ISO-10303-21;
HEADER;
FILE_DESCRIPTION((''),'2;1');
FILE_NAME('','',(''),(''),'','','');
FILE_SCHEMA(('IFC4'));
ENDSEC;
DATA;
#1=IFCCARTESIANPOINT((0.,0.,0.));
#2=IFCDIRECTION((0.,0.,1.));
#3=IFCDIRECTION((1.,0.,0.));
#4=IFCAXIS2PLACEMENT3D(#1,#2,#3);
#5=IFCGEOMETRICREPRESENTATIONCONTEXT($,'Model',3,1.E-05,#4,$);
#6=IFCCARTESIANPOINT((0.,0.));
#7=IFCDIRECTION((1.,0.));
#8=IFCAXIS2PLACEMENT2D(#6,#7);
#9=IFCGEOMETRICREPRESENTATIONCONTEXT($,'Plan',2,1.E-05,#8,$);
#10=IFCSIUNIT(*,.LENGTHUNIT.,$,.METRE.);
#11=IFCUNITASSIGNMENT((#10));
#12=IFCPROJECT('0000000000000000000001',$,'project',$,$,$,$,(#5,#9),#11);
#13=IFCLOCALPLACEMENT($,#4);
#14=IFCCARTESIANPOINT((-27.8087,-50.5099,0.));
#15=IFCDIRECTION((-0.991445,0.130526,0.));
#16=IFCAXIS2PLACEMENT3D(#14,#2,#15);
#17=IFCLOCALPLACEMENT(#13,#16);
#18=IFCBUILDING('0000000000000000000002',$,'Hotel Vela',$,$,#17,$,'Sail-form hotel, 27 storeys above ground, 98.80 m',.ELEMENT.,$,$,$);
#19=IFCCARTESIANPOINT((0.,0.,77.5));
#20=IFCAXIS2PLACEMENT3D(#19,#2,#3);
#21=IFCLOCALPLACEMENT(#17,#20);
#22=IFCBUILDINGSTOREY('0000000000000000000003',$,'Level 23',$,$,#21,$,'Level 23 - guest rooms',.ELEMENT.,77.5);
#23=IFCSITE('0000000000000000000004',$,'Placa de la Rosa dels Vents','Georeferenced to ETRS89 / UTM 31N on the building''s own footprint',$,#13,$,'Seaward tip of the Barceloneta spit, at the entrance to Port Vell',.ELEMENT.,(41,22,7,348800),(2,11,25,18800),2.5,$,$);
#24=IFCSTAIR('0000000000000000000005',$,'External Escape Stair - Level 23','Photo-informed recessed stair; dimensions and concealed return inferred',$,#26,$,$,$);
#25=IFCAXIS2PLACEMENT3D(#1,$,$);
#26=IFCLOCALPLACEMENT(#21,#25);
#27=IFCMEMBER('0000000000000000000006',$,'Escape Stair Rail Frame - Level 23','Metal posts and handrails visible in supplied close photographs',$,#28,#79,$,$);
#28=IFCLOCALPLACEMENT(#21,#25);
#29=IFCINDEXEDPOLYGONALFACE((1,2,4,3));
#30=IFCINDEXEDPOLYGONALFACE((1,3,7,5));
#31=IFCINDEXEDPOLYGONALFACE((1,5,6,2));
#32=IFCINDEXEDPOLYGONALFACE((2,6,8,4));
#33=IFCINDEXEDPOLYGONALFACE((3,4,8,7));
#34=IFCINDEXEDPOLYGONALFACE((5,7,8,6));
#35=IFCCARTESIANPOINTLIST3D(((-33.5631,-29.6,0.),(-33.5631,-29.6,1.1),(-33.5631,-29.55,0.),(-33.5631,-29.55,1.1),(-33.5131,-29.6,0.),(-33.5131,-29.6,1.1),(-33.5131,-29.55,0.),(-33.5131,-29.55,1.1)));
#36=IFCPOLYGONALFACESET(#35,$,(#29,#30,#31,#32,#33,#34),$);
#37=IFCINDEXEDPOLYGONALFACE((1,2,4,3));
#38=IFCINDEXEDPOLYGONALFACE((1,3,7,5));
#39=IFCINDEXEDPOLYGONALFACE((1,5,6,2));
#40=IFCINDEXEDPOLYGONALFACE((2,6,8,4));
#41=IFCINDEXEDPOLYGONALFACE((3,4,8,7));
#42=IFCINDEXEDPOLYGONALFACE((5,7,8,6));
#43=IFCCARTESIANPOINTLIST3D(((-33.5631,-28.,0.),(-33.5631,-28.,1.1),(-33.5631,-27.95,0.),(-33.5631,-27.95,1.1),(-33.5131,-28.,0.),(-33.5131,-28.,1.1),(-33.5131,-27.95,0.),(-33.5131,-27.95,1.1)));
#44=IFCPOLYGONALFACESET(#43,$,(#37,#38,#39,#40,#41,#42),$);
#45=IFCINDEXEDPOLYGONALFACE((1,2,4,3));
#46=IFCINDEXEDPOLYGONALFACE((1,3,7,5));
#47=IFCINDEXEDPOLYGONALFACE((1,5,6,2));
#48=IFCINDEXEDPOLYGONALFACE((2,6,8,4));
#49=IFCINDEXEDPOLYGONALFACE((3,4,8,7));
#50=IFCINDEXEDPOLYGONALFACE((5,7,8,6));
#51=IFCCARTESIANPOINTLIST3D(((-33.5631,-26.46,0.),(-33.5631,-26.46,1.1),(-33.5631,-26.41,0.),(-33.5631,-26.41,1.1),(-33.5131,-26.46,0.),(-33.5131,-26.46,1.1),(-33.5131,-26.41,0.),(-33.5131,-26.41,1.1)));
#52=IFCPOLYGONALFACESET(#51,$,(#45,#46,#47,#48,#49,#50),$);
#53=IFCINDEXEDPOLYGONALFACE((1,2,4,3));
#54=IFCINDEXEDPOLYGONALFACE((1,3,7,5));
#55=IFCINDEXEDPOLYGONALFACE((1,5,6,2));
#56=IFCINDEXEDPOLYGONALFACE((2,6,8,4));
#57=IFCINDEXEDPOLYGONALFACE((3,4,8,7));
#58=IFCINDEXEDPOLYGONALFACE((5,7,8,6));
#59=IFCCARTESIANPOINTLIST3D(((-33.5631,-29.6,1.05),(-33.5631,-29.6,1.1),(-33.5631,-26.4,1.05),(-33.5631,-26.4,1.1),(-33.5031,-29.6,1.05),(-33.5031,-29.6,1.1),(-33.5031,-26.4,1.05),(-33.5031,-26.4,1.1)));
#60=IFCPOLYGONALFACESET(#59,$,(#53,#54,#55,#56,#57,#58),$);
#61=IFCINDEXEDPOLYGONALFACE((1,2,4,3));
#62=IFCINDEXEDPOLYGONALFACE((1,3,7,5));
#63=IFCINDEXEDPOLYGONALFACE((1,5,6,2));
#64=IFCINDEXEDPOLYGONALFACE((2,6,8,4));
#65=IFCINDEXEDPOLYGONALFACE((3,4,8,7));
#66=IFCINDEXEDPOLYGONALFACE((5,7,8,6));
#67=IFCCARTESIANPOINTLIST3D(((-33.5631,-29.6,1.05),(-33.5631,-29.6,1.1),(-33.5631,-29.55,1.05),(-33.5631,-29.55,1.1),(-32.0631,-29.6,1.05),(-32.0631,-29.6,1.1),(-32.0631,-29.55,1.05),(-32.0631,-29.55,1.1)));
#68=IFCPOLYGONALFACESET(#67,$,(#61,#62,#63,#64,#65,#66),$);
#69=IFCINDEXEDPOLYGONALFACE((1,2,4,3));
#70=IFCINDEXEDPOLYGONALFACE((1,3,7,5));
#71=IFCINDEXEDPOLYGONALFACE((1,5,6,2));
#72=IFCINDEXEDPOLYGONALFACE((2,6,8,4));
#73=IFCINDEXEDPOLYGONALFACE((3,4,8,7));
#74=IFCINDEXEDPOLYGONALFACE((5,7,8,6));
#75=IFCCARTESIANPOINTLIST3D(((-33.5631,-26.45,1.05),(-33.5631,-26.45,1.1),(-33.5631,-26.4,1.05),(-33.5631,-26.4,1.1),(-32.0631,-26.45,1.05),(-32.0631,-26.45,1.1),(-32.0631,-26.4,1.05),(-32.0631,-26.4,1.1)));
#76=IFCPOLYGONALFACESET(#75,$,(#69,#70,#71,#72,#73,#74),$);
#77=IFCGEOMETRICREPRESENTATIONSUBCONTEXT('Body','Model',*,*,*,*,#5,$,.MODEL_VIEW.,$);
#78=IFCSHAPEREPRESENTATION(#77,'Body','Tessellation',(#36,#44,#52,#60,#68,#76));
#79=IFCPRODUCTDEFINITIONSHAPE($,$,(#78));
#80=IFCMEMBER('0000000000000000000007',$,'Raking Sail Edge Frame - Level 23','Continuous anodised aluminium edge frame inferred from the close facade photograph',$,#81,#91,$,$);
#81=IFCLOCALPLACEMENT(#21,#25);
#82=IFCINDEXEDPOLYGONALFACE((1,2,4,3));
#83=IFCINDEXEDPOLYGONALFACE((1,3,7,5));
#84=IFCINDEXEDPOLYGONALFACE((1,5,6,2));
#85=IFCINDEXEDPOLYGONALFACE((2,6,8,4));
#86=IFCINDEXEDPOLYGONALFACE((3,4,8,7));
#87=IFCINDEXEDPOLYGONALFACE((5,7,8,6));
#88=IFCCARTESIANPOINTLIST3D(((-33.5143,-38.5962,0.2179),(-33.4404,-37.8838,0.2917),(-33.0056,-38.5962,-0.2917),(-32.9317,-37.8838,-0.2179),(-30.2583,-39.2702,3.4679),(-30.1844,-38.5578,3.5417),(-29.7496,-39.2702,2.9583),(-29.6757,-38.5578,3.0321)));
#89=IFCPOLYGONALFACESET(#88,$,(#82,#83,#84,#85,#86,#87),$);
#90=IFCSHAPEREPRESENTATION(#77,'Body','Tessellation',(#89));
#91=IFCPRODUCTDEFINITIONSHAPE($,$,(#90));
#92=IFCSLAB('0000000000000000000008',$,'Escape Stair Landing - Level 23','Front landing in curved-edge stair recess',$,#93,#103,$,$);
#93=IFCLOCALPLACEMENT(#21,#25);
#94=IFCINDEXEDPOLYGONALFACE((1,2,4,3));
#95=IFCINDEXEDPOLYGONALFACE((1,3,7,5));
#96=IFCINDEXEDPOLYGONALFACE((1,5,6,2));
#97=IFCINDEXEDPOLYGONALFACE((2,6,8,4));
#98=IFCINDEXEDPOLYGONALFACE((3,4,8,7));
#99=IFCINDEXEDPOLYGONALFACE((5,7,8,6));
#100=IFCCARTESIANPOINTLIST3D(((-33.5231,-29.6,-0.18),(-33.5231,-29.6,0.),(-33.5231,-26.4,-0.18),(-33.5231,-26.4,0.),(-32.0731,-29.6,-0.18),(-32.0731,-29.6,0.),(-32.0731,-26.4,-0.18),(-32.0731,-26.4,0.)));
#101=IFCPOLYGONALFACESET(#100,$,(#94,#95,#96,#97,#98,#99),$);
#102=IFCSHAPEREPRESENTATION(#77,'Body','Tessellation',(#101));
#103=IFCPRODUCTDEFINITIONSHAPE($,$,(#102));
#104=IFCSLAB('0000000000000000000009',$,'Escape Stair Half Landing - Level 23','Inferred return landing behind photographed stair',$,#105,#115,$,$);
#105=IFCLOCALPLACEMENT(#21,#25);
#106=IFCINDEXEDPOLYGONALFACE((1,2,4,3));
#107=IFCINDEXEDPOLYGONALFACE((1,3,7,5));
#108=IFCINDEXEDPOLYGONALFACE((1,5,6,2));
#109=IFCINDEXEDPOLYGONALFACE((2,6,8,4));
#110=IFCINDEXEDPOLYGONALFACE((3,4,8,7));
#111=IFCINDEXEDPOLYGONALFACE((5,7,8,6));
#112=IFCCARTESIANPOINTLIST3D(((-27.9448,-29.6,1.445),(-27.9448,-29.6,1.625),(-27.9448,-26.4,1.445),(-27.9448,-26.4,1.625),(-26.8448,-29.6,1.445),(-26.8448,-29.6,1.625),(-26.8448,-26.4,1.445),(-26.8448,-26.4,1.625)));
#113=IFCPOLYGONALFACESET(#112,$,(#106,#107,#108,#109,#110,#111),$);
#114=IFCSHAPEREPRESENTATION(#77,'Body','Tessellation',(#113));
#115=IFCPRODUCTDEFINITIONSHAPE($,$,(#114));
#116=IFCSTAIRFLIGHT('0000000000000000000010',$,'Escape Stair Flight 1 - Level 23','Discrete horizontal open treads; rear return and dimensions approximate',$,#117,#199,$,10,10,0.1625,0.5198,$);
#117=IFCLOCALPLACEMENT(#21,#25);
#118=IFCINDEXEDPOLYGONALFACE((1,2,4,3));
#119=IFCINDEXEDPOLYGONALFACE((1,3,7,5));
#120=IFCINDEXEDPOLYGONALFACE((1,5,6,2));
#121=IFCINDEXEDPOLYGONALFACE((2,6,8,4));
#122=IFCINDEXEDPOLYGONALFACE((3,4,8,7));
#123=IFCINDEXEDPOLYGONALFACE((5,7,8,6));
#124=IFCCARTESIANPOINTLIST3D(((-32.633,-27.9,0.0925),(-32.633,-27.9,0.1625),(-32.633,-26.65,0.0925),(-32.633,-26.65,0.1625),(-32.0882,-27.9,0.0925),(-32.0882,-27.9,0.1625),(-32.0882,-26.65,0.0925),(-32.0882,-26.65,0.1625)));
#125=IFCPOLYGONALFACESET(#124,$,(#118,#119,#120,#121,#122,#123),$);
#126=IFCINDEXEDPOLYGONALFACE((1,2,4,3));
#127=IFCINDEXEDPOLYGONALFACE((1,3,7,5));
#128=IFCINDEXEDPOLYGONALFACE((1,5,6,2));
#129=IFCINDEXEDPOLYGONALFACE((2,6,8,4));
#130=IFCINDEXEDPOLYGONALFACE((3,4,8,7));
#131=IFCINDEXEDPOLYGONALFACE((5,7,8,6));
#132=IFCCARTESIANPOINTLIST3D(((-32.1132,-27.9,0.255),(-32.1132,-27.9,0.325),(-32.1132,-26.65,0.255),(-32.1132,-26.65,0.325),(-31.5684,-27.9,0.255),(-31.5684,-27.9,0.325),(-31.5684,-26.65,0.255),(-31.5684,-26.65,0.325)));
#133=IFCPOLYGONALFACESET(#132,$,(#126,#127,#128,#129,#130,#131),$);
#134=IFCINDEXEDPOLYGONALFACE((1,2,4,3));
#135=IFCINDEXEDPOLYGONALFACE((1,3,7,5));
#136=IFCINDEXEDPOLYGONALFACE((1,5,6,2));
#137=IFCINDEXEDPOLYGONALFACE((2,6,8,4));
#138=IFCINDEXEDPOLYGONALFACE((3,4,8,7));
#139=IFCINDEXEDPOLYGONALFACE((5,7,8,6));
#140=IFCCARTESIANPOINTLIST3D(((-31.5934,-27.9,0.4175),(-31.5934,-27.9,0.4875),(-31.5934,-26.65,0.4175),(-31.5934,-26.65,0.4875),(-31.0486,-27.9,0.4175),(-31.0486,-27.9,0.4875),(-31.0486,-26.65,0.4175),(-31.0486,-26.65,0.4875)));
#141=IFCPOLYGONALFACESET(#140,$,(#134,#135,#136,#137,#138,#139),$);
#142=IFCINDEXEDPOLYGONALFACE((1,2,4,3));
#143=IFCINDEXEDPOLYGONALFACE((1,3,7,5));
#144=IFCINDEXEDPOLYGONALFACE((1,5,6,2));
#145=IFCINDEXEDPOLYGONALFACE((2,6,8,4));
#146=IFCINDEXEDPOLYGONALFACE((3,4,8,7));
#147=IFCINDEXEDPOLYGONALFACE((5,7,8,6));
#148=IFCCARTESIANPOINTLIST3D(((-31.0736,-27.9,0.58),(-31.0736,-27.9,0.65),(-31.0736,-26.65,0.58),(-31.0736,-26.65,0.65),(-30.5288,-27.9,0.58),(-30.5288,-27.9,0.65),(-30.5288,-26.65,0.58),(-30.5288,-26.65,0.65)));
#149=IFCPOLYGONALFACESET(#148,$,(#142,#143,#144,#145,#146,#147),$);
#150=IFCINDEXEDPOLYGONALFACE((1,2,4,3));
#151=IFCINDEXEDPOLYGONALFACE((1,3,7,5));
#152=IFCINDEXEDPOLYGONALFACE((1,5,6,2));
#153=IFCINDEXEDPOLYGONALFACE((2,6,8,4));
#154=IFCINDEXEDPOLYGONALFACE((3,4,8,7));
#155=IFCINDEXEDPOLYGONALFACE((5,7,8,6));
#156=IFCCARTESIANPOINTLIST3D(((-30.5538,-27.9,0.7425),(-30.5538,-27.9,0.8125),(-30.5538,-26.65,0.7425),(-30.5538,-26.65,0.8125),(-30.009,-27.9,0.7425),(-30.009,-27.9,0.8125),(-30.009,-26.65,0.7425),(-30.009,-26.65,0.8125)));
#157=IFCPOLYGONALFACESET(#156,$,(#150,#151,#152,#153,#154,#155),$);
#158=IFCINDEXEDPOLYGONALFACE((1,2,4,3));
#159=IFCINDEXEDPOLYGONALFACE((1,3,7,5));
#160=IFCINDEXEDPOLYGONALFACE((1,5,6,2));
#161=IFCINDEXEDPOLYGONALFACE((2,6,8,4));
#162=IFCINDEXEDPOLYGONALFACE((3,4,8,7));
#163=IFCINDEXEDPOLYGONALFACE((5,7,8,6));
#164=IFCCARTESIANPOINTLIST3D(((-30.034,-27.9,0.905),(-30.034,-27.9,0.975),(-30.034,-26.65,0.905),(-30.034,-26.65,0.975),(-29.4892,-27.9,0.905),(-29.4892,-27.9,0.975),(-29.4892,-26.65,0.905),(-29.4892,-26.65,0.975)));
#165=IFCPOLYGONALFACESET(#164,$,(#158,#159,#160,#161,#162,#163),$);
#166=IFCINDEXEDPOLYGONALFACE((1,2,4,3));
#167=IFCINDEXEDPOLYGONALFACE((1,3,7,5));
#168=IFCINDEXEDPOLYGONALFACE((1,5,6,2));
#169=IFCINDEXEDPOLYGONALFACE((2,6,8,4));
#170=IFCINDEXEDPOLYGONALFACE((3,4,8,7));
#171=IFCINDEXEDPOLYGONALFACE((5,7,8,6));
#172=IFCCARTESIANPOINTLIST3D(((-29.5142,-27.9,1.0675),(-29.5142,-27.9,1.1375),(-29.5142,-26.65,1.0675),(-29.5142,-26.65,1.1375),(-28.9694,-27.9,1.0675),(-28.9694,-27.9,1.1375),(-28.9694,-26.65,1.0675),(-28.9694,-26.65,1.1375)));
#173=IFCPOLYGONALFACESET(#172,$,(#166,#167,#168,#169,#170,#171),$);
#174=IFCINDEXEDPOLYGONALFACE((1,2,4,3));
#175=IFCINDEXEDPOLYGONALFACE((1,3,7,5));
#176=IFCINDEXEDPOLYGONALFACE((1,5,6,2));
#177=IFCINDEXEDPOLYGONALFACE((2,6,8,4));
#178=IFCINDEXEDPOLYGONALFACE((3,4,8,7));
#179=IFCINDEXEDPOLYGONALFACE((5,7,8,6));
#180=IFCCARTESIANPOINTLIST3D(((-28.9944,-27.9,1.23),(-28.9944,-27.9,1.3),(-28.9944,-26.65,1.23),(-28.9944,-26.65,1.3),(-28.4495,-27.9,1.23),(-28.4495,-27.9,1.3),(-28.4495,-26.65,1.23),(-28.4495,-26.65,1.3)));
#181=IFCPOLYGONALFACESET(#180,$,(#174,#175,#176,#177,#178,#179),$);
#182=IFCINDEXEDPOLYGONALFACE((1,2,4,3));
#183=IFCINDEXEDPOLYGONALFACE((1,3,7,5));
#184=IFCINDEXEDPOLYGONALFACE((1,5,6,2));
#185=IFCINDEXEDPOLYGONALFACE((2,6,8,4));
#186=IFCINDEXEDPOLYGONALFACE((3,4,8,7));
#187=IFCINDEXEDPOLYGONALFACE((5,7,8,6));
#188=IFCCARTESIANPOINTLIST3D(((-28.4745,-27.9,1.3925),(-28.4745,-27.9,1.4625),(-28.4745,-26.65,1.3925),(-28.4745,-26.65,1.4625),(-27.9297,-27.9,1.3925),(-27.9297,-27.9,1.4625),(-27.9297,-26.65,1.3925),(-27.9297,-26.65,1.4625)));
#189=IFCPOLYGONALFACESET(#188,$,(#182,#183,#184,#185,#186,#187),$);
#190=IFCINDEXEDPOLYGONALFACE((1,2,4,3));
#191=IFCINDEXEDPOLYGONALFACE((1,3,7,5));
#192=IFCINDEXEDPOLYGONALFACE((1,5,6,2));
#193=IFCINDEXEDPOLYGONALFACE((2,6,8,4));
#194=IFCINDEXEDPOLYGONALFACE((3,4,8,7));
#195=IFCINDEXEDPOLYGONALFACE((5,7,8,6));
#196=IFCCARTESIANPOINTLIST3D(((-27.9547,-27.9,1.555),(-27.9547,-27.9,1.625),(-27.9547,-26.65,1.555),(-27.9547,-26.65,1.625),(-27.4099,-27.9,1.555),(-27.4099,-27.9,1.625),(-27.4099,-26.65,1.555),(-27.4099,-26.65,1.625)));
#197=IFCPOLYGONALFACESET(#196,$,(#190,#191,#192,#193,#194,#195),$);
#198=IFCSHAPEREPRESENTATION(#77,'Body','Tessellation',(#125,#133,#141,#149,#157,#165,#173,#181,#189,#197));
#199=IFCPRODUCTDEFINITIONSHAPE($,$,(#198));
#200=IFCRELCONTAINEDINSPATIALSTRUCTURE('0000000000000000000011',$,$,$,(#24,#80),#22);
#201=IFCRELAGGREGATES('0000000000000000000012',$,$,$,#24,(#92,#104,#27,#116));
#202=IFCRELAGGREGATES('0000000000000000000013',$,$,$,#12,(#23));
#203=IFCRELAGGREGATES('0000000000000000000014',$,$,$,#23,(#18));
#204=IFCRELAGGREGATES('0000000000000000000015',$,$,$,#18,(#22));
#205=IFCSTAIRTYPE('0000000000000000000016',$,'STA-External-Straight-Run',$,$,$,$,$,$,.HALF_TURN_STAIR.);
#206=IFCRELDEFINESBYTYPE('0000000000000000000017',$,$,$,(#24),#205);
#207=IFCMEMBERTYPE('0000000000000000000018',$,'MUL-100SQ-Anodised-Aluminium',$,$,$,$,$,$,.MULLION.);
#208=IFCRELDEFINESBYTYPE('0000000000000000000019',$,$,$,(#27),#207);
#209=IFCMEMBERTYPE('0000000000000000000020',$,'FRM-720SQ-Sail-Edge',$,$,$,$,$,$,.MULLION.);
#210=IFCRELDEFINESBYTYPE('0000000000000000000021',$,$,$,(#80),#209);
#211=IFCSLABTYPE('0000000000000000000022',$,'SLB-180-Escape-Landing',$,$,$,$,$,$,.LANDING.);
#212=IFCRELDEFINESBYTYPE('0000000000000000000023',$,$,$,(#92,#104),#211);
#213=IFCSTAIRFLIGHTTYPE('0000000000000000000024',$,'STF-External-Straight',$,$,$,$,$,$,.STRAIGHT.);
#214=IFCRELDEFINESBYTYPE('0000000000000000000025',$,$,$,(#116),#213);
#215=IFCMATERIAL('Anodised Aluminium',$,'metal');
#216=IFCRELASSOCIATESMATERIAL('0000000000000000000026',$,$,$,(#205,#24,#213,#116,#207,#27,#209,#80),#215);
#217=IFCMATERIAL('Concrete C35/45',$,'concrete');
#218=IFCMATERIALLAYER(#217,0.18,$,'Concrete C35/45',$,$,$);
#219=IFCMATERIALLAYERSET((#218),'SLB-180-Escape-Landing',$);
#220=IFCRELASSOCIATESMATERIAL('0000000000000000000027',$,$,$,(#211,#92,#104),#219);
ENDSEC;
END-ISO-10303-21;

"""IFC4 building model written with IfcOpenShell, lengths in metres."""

from ifc_helpers import new_model, si_unit, frame, origin_with_axes, origin_2d_with_axis, place, context, subcontext, project, spatial, line, indexed_curve, rectangle, outline, extrude, material, layer, layer_set, layer_usage, material_profile, profile_set, profile_usage, type_object, element, aggregate, save


model = new_model("IFC4")

# Units and contexts
model_context = context("Model", 3, precision=1e-05, world=origin_with_axes())
plan_context = context("Plan", 2, precision=1e-05, world=origin_2d_with_axis())
body_context = subcontext(model_context, "Body", "Model", "MODEL_VIEW")
ifc_project = project(units=[si_unit("LENGTHUNIT", "METRE")], contexts=[model_context, plan_context])

# Site, building, storey
site_placement = place(None, origin_with_axes())
site = spatial("IfcSite", under=ifc_project, at=site_placement, Name="Placa de la Rosa dels Vents", Description="Georeferenced to ETRS89 / UTM 31N on the building's own footprint", LongName="Seaward tip of the Barceloneta spit, at the entrance to Port Vell", CompositionType="ELEMENT", RefLatitude=(41, 22, 7, 348800), RefLongitude=(2, 11, 25, 18800), RefElevation=2.5)
building_placement = place(site_placement, frame((-27.8087, -50.5099, 0.0), z_axis=(0.0, 0.0, 1.0), x_axis=(-0.991445, 0.130526, 0.0)))
building = spatial("IfcBuilding", under=site, at=building_placement, Name="Hotel Vela", LongName="Sail-form hotel, 27 storeys above ground, 98.80 m", CompositionType="ELEMENT")
storey_placement = place(building_placement, frame((0.0, 0.0, 77.5), z_axis=(0.0, 0.0, 1.0), x_axis=(1.0, 0.0, 0.0)))
storey = spatial("IfcBuildingStorey", under=building, at=storey_placement, Name="Level 23", LongName="Level 23 - guest rooms", CompositionType="ELEMENT", Elevation=77.5)

# Stair, member
ifc_material_1 = material(Name="Anodised Aluminium", Category="metal")
stair_type = type_object("IfcStairType", Name="STA-External-Straight-Run", PredefinedType="HALF_TURN_STAIR", material=ifc_material_1)
stair_placement = place(storey_placement, frame((0.0, 0.0, -77.5), z_axis=(0.0, 0.0, 1.0), x_axis=(1.0, 0.0, 0.0)))
stair = element("IfcStair", 1, at=stair_placement, inside=storey, type_object=stair_type, material=ifc_material_1, Name="External Escape Stair - Level 23", Description="Photo-informed recessed stair; dimensions and concealed return inferred")
ifc_material_profile_1 = material_profile(ifc_material_1, rectangle(XDim=0.1, YDim=0.1))
ifc_profile_set_1 = profile_set([ifc_material_profile_1], Name="MUL-100SQ-Anodised-Aluminium")
ifc_profile_usage_1 = profile_usage(ifc_profile_set_1)
member_type_1 = type_object("IfcMemberType", Name="MUL-100SQ-Anodised-Aluminium", PredefinedType="MULLION", material=ifc_profile_set_1)
member_1_placement = place(stair_placement, origin_with_axes())
member_1 = element("IfcMember", 2, at=member_1_placement, type_object=member_type_1, material=ifc_profile_usage_1, Name="Escape Stair Rail Frame - Level 23", Description="Metal posts and handrails visible in supplied close photographs", context=body_context, shape_type="SweptSolid", body=[
    extrude(outline(indexed_curve([(0.0, 0.0), (0.05, 0.0), (0.05, 0.05), (0.0, 0.05)], segments=[line(1, 2, 3, 4, 1)])), frame((-33.5631, -29.6, 77.5), z_axis=(0.0, 0.0, 1.0), x_axis=(1.0, 0.0, 0.0)), (0.0, 0.0, 1.0), 1.1),
    extrude(outline(indexed_curve([(0.0, 0.0), (0.05, 0.0), (0.05, 0.05), (0.0, 0.05)], segments=[line(1, 2, 3, 4, 1)])), frame((-33.5631, -28.0, 77.5), z_axis=(0.0, 0.0, 1.0), x_axis=(1.0, 0.0, 0.0)), (0.0, 0.0, 1.0), 1.1),
    extrude(outline(indexed_curve([(0.0, 0.0), (0.05, 0.0), (0.05, 0.05), (0.0, 0.05)], segments=[line(1, 2, 3, 4, 1)])), frame((-33.5631, -26.46, 77.5), z_axis=(0.0, 0.0, 1.0), x_axis=(1.0, 0.0, 0.0)), (0.0, 0.0, 1.0), 1.1),
    extrude(outline(indexed_curve([(0.0, 0.0), (0.06, 0.0), (0.06, 3.2), (0.0, 3.2)], segments=[line(1, 2, 3, 4, 1)])), frame((-33.5631, -29.6, 78.55), z_axis=(0.0, 0.0, 1.0), x_axis=(1.0, 0.0, 0.0)), (0.0, 0.0, 1.0), 0.05),
    extrude(outline(indexed_curve([(0.0, 0.0), (1.5, 0.0), (1.5, 0.05), (0.0, 0.05)], segments=[line(1, 2, 3, 4, 1)])), frame((-33.5631, -29.6, 78.55), z_axis=(0.0, 0.0, 1.0), x_axis=(1.0, 0.0, 0.0)), (0.0, 0.0, 1.0), 0.05),
    extrude(outline(indexed_curve([(0.0, 0.0), (1.5, 0.0), (1.5, 0.05), (0.0, 0.05)], segments=[line(1, 2, 3, 4, 1)])), frame((-33.5631, -26.45, 78.55), z_axis=(0.0, 0.0, 1.0), x_axis=(1.0, 0.0, 0.0)), (0.0, 0.0, 1.0), 0.05),
])

# Member
ifc_material_profile_2 = material_profile(ifc_material_1, rectangle(XDim=0.72, YDim=0.72))
ifc_profile_set_2 = profile_set([ifc_material_profile_2], Name="FRM-720SQ-Sail-Edge")
ifc_profile_usage_2 = profile_usage(ifc_profile_set_2)
member_type_2 = type_object("IfcMemberType", Name="FRM-720SQ-Sail-Edge", PredefinedType="MULLION", material=ifc_profile_set_2)
member_2_placement = place(storey_placement, frame((-33.223, -38.24, 0.0), z_axis=(0.700283, -0.14496, 0.698992), x_axis=(0.706454, 0.0, -0.707759)))
element("IfcMember", 3, at=member_2_placement, inside=storey, type_object=member_type_2, material=ifc_profile_usage_2, Name="Raking Sail Edge Frame - Level 23", Description="Continuous anodised aluminium edge frame inferred from the close facade photograph", context=body_context, shape_type="SweptSolid", body=[
    extrude(outline(indexed_curve([(-0.36, -0.36), (0.36, -0.36), (0.36, 0.36), (-0.36, 0.36)], segments=[line(1, 2, 3, 4, 1)])), origin_with_axes(), (0.0, 0.0, 1.0), 4.6495),
])

# Slabs
ifc_material_2 = material(Name="Concrete C35/45", Category="concrete")
ifc_layer = layer(ifc_material_2, 0.18, Name="Concrete C35/45")
ifc_layer_set = layer_set([ifc_layer], Name="SLB-180-Escape-Landing")
ifc_layer_usage_1 = layer_usage(ifc_layer_set, "AXIS3", "POSITIVE", 0.0)
slab_type = type_object("IfcSlabType", Name="SLB-180-Escape-Landing", PredefinedType="LANDING", material=ifc_layer_set)
slab_1_placement = place(stair_placement, frame((-33.5231, -29.6, 77.32), z_axis=(0.0, 0.0, 1.0), x_axis=(1.0, 0.0, 0.0)))
slab_1 = element("IfcSlab", 4, at=slab_1_placement, type_object=slab_type, material=ifc_layer_usage_1, Name="Escape Stair Landing - Level 23", Description="Front landing in curved-edge stair recess", context=body_context, shape_type="SweptSolid", body=[
    extrude(outline(indexed_curve([(0.0, 0.0), (1.45, 0.0), (1.45, 3.2), (0.0, 3.2)], segments=[line(1, 2, 3, 4, 1)])), origin_with_axes(), (0.0, 0.0, 1.0), 0.18),
])
ifc_layer_usage_2 = layer_usage(ifc_layer_set, "AXIS3", "POSITIVE", 0.0)
slab_2_placement = place(stair_placement, frame((-27.9448, -29.6, 78.945), z_axis=(0.0, 0.0, 1.0), x_axis=(1.0, 0.0, 0.0)))
slab_2 = element("IfcSlab", 5, at=slab_2_placement, type_object=slab_type, material=ifc_layer_usage_2, Name="Escape Stair Half Landing - Level 23", Description="Inferred return landing behind photographed stair", context=body_context, shape_type="SweptSolid", body=[
    extrude(outline(indexed_curve([(0.0, 0.0), (1.1, 0.0), (1.1, 3.2), (0.0, 3.2)], segments=[line(1, 2, 3, 4, 1)])), origin_with_axes(), (0.0, 0.0, 1.0), 0.18),
])

# Stair flight
stair_flight_type = type_object("IfcStairFlightType", Name="STF-External-Straight", PredefinedType="STRAIGHT", material=ifc_material_1)
stair_flight_1_placement = place(stair_placement, origin_with_axes())
stair_flight_1 = element("IfcStairFlight", 6, at=stair_flight_1_placement, type_object=stair_flight_type, material=ifc_material_1, Name="Escape Stair Flight 1 - Level 23", Description="Discrete horizontal open treads; rear return and dimensions approximate", NumberOfRisers=10, NumberOfTreads=10, RiserHeight=0.1625, TreadLength=0.5198, context=body_context, shape_type="SweptSolid", body=[
    extrude(outline(indexed_curve([(0.0, 0.0), (0.5448, 0.0), (0.5448, 1.25), (0.0, 1.25)], segments=[line(1, 2, 3, 4, 1)])), frame((-32.633, -27.9, 77.5925), z_axis=(0.0, 0.0, 1.0), x_axis=(1.0, 0.0, 0.0)), (0.0, 0.0, 1.0), 0.07),
    extrude(outline(indexed_curve([(0.0, 0.0), (0.5448, 0.0), (0.5448, 1.25), (0.0, 1.25)], segments=[line(1, 2, 3, 4, 1)])), frame((-32.1132, -27.9, 77.755), z_axis=(0.0, 0.0, 1.0), x_axis=(1.0, 0.0, 0.0)), (0.0, 0.0, 1.0), 0.07),
    extrude(outline(indexed_curve([(0.0, 0.0), (0.5448, 0.0), (0.5448, 1.25), (0.0, 1.25)], segments=[line(1, 2, 3, 4, 1)])), frame((-31.5934, -27.9, 77.9175), z_axis=(0.0, 0.0, 1.0), x_axis=(1.0, 0.0, 0.0)), (0.0, 0.0, 1.0), 0.07),
    extrude(outline(indexed_curve([(0.0, 0.0), (0.5448, 0.0), (0.5448, 1.25), (0.0, 1.25)], segments=[line(1, 2, 3, 4, 1)])), frame((-31.0736, -27.9, 78.08), z_axis=(0.0, 0.0, 1.0), x_axis=(1.0, 0.0, 0.0)), (0.0, 0.0, 1.0), 0.07),
    extrude(outline(indexed_curve([(0.0, 0.0), (0.5448, 0.0), (0.5448, 1.25), (0.0, 1.25)], segments=[line(1, 2, 3, 4, 1)])), frame((-30.5538, -27.9, 78.2425), z_axis=(0.0, 0.0, 1.0), x_axis=(1.0, 0.0, 0.0)), (0.0, 0.0, 1.0), 0.07),
    extrude(outline(indexed_curve([(0.0, 0.0), (0.5448, 0.0), (0.5448, 1.25), (0.0, 1.25)], segments=[line(1, 2, 3, 4, 1)])), frame((-30.034, -27.9, 78.405), z_axis=(0.0, 0.0, 1.0), x_axis=(1.0, 0.0, 0.0)), (0.0, 0.0, 1.0), 0.07),
    extrude(outline(indexed_curve([(0.0, 0.0), (0.5448, 0.0), (0.5448, 1.25), (0.0, 1.25)], segments=[line(1, 2, 3, 4, 1)])), frame((-29.5142, -27.9, 78.5675), z_axis=(0.0, 0.0, 1.0), x_axis=(1.0, 0.0, 0.0)), (0.0, 0.0, 1.0), 0.07),
    extrude(outline(indexed_curve([(0.0, 0.0), (0.5448, 0.0), (0.5448, 1.25), (0.0, 1.25)], segments=[line(1, 2, 3, 4, 1)])), frame((-28.9944, -27.9, 78.73), z_axis=(0.0, 0.0, 1.0), x_axis=(1.0, 0.0, 0.0)), (0.0, 0.0, 1.0), 0.07),
    extrude(outline(indexed_curve([(0.0, 0.0), (0.5448, 0.0), (0.5448, 1.25), (0.0, 1.25)], segments=[line(1, 2, 3, 4, 1)])), frame((-28.4745, -27.9, 78.8925), z_axis=(0.0, 0.0, 1.0), x_axis=(1.0, 0.0, 0.0)), (0.0, 0.0, 1.0), 0.07),
    extrude(outline(indexed_curve([(0.0, 0.0), (0.5448, 0.0), (0.5448, 1.25), (0.0, 1.25)], segments=[line(1, 2, 3, 4, 1)])), frame((-27.9547, -27.9, 79.055), z_axis=(0.0, 0.0, 1.0), x_axis=(1.0, 0.0, 0.0)), (0.0, 0.0, 1.0), 0.07),
])

aggregate(stair, [slab_1, slab_2, member_1, stair_flight_1])

save(model, "model.ifc")
